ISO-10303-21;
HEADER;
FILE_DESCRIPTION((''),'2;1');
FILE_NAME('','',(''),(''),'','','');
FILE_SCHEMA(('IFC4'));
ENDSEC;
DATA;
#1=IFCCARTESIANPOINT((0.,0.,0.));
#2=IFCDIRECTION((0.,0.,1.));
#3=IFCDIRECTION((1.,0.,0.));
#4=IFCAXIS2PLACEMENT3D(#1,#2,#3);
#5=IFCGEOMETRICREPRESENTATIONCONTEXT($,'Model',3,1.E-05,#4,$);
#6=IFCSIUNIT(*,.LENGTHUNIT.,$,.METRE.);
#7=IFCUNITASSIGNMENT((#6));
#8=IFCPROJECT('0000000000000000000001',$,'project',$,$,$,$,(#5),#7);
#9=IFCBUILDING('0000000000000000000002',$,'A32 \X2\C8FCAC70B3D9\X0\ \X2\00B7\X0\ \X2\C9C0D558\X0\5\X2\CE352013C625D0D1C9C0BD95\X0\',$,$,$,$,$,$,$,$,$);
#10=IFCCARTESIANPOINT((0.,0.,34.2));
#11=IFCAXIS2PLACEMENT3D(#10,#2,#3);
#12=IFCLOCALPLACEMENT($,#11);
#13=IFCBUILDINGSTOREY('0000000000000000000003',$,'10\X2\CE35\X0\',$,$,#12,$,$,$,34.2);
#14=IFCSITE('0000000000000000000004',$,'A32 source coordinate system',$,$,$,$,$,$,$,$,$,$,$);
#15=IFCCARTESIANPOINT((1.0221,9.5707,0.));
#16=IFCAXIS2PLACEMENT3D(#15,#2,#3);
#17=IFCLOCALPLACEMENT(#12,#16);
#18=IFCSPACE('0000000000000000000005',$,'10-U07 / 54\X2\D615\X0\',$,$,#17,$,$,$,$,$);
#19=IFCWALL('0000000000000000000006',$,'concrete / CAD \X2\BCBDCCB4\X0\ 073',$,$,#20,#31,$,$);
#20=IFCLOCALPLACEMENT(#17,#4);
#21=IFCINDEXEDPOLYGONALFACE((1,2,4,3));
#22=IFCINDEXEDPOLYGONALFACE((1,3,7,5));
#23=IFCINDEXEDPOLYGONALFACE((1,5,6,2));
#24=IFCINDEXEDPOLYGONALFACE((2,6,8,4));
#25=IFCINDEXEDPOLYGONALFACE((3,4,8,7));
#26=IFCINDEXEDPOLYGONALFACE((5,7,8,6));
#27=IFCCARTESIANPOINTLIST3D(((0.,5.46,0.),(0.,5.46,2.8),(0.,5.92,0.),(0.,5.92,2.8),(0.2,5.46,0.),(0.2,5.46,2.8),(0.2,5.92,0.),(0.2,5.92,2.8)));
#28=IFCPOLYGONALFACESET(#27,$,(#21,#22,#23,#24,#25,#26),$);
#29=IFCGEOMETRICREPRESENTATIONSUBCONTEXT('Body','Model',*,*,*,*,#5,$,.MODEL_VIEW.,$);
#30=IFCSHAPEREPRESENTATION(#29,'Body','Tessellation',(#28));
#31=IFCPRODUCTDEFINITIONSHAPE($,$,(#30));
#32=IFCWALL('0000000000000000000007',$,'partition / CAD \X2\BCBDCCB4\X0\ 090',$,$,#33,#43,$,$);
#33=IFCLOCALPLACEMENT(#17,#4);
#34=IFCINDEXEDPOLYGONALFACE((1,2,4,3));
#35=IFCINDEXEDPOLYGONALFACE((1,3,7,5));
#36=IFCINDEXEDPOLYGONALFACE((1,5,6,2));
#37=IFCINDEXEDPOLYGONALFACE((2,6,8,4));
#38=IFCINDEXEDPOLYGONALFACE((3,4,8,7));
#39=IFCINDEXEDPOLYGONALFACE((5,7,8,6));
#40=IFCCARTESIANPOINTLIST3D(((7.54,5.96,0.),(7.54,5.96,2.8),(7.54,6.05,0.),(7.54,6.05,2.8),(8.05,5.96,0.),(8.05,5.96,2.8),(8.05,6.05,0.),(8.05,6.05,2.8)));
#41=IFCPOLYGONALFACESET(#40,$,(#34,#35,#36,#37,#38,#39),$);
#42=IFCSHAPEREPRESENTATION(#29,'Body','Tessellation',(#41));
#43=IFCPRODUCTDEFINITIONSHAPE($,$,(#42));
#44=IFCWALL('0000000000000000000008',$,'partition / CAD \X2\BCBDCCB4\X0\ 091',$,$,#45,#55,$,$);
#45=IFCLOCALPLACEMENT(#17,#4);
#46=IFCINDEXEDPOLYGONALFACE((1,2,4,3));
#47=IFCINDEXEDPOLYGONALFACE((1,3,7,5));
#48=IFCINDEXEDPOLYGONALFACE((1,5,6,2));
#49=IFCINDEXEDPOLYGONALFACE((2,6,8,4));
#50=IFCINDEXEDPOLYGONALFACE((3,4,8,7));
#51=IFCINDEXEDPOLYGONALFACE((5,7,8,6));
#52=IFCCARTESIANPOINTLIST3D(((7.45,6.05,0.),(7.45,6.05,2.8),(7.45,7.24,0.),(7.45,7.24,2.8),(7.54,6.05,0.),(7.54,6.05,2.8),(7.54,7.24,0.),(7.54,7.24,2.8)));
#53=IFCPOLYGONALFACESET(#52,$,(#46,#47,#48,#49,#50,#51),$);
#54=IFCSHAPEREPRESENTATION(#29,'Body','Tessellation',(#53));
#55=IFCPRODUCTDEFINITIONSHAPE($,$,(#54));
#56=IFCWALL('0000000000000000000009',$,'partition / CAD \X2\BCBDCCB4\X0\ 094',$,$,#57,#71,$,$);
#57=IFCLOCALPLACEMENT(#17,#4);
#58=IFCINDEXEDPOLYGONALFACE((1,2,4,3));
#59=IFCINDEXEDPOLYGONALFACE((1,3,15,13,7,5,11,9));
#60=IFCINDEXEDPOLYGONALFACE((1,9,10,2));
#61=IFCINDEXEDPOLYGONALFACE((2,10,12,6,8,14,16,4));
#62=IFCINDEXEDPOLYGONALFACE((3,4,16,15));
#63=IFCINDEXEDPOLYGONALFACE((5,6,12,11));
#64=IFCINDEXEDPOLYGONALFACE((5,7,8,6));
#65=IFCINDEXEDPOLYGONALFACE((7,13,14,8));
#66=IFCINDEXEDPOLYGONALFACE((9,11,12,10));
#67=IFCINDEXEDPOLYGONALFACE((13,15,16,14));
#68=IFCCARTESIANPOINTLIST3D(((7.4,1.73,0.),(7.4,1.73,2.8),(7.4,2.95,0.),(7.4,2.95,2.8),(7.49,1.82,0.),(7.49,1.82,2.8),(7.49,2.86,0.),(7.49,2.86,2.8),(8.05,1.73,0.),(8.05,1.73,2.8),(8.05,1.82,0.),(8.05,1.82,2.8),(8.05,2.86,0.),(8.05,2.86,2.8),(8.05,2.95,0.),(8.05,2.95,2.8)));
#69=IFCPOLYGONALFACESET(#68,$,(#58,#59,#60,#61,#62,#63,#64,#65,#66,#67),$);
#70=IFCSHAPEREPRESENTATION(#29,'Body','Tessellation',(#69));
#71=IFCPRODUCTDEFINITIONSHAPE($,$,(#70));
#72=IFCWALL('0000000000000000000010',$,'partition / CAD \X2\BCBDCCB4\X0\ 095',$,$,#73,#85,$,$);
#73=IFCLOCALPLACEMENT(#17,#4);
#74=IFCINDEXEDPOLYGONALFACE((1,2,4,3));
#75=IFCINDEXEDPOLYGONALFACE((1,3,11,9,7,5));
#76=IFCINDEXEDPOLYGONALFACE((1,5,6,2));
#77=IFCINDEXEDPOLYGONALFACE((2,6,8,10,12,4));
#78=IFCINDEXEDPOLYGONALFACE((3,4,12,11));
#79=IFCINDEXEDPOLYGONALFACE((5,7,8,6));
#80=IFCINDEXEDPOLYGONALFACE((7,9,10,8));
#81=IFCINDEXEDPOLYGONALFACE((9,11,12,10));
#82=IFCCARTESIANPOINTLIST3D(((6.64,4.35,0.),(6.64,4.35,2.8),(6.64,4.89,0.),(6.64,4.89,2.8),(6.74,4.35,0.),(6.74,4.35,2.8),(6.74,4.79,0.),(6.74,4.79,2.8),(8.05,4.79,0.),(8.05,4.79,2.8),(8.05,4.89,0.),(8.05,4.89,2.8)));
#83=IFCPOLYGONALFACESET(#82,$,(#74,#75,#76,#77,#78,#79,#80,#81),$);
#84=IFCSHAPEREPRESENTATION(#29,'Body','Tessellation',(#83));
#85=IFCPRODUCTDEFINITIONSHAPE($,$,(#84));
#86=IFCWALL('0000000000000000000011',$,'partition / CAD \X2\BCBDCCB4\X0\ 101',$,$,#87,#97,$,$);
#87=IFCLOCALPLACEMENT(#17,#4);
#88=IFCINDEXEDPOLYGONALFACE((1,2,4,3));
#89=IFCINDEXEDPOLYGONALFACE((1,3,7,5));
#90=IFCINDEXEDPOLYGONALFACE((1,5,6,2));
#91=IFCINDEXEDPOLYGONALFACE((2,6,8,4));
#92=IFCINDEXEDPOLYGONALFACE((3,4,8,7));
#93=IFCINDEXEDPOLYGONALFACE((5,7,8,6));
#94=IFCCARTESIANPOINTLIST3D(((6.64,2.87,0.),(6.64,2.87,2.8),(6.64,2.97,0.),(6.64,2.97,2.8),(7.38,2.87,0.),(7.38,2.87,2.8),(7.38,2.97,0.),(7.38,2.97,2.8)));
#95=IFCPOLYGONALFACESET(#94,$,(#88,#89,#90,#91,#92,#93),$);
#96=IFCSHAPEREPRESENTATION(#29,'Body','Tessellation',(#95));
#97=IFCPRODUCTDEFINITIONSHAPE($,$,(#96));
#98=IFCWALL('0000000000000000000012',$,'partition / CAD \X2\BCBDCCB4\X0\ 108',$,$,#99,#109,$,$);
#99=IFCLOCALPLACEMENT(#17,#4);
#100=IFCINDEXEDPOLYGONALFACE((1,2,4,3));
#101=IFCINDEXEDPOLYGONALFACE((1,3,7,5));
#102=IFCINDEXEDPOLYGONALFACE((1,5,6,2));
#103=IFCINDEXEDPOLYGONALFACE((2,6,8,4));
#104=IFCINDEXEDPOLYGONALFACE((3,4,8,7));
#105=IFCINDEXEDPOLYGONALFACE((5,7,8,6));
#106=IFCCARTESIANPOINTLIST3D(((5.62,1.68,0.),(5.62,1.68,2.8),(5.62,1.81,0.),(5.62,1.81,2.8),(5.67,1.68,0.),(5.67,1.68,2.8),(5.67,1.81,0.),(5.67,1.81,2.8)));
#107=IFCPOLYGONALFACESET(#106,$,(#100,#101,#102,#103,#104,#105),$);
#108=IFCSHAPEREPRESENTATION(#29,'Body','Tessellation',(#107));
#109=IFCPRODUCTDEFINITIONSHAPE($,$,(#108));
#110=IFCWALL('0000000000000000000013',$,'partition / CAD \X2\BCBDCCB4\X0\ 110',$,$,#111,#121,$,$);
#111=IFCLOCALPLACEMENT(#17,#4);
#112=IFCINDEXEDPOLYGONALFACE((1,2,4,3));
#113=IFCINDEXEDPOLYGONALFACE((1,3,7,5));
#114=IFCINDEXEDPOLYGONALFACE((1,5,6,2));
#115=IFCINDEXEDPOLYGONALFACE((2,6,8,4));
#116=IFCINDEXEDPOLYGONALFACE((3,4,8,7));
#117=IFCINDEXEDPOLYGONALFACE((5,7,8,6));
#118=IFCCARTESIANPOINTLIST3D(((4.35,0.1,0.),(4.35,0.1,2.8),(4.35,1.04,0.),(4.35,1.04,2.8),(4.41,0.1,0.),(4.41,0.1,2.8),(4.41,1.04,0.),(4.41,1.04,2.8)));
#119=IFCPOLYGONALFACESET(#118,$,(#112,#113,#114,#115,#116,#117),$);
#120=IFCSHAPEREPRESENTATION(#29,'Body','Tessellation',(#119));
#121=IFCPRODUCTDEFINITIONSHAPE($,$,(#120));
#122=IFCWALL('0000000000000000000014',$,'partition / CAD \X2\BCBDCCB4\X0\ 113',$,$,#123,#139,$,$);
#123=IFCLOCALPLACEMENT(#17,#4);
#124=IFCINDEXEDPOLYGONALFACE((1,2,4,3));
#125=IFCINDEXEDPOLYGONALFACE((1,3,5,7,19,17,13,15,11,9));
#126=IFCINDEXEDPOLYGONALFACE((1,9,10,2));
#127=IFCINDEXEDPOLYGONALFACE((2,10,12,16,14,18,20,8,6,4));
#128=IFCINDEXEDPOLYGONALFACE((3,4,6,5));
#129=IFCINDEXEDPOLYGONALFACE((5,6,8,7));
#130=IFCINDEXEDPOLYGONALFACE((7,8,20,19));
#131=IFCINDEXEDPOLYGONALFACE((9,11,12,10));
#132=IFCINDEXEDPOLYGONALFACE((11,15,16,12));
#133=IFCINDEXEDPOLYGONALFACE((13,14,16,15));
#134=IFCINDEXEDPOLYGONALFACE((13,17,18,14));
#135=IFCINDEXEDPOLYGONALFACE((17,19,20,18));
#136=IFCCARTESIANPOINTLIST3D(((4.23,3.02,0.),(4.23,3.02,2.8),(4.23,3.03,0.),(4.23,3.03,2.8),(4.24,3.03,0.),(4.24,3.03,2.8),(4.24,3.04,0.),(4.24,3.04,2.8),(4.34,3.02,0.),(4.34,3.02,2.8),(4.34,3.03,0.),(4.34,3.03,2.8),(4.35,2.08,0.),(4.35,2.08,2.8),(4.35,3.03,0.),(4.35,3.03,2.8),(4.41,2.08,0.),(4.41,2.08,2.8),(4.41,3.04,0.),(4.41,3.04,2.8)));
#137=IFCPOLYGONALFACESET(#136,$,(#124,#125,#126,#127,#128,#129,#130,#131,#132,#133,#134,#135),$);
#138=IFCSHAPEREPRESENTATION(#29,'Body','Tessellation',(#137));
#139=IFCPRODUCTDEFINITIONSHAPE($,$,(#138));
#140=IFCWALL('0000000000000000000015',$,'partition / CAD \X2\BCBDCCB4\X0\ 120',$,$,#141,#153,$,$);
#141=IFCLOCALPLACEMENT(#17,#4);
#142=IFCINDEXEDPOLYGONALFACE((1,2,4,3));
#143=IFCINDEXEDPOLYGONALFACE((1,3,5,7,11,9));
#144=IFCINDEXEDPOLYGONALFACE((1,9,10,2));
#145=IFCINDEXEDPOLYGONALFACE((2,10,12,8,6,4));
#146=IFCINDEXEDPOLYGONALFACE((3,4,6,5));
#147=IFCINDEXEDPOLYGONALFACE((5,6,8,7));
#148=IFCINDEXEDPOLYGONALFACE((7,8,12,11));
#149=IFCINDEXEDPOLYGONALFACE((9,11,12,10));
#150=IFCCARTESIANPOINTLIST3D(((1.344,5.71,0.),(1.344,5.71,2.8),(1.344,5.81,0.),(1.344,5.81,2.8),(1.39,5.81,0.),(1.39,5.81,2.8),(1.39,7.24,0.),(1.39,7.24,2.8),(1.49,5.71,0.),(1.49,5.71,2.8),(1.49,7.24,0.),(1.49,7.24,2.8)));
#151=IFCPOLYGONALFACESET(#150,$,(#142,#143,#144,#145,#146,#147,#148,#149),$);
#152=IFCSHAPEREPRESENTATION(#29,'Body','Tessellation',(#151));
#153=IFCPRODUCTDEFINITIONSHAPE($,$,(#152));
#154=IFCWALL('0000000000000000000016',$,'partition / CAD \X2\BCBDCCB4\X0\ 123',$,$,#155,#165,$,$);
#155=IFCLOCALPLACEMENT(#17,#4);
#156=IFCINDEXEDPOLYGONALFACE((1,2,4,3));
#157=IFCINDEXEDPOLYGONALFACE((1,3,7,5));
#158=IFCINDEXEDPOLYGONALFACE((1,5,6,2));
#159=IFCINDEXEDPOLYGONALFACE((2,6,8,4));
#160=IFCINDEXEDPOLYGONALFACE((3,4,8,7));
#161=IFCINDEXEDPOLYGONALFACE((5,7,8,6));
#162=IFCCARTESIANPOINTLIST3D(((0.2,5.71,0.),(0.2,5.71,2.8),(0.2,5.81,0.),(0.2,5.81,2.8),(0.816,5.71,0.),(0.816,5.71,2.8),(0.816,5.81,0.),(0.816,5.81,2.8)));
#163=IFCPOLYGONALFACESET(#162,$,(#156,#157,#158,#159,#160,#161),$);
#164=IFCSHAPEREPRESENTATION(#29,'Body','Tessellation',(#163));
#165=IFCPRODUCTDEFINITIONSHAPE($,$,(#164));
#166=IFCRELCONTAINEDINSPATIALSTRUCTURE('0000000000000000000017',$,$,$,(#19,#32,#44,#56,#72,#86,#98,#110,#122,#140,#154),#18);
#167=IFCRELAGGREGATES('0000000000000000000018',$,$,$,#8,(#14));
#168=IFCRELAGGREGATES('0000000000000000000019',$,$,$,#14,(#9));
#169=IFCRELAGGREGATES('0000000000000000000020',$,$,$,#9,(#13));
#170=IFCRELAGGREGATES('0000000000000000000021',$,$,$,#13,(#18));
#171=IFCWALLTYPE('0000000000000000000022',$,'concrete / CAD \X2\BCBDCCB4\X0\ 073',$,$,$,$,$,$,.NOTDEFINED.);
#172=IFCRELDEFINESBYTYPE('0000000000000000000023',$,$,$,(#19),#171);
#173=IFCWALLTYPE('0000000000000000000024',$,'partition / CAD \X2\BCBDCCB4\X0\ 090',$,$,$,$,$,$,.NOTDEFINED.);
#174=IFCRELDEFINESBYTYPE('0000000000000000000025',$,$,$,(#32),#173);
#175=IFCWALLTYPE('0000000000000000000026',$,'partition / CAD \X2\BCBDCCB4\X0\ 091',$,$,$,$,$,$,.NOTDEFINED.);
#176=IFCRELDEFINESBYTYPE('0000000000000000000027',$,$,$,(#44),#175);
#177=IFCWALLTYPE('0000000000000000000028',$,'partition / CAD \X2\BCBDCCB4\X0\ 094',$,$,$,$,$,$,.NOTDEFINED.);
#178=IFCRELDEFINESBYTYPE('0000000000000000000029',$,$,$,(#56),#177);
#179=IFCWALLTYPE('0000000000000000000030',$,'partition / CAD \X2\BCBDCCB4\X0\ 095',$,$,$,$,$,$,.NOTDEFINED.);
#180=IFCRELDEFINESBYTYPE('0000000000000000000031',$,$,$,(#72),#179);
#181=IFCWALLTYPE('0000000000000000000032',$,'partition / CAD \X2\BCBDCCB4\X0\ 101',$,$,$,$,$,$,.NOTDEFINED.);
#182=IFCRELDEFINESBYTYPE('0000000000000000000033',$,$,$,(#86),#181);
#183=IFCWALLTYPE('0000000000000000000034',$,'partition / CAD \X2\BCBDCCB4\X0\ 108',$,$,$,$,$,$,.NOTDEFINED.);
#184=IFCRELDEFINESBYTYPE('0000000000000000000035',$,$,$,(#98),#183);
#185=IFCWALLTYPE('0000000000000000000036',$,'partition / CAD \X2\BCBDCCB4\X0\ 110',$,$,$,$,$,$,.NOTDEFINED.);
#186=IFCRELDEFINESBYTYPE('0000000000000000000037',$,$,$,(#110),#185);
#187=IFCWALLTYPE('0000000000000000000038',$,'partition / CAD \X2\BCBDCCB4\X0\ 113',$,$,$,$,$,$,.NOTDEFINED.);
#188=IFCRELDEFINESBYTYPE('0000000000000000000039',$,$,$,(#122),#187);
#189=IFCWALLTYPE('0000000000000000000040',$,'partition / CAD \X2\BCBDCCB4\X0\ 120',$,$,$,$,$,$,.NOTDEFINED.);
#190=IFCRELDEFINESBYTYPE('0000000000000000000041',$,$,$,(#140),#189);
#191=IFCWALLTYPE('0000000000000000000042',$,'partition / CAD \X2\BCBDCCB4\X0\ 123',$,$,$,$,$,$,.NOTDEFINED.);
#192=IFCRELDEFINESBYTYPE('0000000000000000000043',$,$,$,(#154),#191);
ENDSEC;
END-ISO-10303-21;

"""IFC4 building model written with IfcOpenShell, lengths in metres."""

from ifc_helpers import new_model, si_unit, frame, origin, origin_with_axes, place, context, subcontext, project, spatial, polyline, outline, extrude, source, transform, mapped, type_object, type_shapes, element, save


model = new_model("IFC4")

# Units and contexts
model_context = context("Model", 3, precision=1e-05, world=origin_with_axes())
body_context = subcontext(model_context, "Body", "Model", "MODEL_VIEW")
ifc_project = project(units=[si_unit("LENGTHUNIT", "METRE")], contexts=[model_context])

# Site, building, storey, space
site = spatial("IfcSite", under=ifc_project, Name="A32 source coordinate system")
building = spatial("IfcBuilding", under=site, Name="A32 주거동 · 지하5층–옥탑지붕")
storey_placement = place(None, frame((0.0, 0.0, 34.2), z_axis=(0.0, 0.0, 1.0), x_axis=(1.0, 0.0, 0.0)))
storey = spatial("IfcBuildingStorey", under=building, at=storey_placement, Name="10층", Elevation=34.2)
space_1_placement = place(storey_placement, frame((1.0221, 9.5707, 0.0), z_axis=(0.0, 0.0, 1.0), x_axis=(1.0, 0.0, 0.0)))
space_1 = spatial("IfcSpace", under=storey, at=space_1_placement, Name="10-U07 / 54형")

# Walls
wall_type_1 = type_object("IfcWallType", Name="concrete / CAD 벽체 073", PredefinedType="NOTDEFINED")
shared_shape_1 = source(origin(), body_context, "Body", "SweptSolid", [
    extrude(outline(polyline([(0.2, 5.92), (0.2, 5.46), (0.0, 5.46), (0.0, 5.92), (0.2, 5.92)])), origin(), (0.0, 0.0, 1.0), 2.8),
])
type_shapes(wall_type_1, [shared_shape_1])
wall_1_placement = place(space_1_placement, origin_with_axes())
element("IfcWall", 1, at=wall_1_placement, inside=space_1, type_object=wall_type_1, Name="concrete / CAD 벽체 073", context=body_context, shape_type="MappedRepresentation", body=[
    mapped(shared_shape_1, transform((0.0, 0.0, 0.0), scale=1.0)),
])
wall_type_2 = type_object("IfcWallType", Name="partition / CAD 벽체 090", PredefinedType="NOTDEFINED")
shared_shape_2 = source(origin(), body_context, "Body", "SweptSolid", [
    extrude(outline(polyline([(7.54, 5.96), (7.54, 6.05), (8.05, 6.05), (8.05, 5.96), (7.54, 5.96)])), origin(), (0.0, 0.0, 1.0), 2.8),
])
type_shapes(wall_type_2, [shared_shape_2])
wall_2_placement = place(space_1_placement, origin_with_axes())
element("IfcWall", 2, at=wall_2_placement, inside=space_1, type_object=wall_type_2, Name="partition / CAD 벽체 090", context=body_context, shape_type="MappedRepresentation", body=[
    mapped(shared_shape_2, transform((0.0, 0.0, 0.0), scale=1.0)),
])
wall_type_3 = type_object("IfcWallType", Name="partition / CAD 벽체 091", PredefinedType="NOTDEFINED")
shared_shape_3 = source(origin(), body_context, "Body", "SweptSolid", [
    extrude(outline(polyline([(7.54, 6.05), (7.45, 6.05), (7.45, 7.24), (7.54, 7.24), (7.54, 6.05)])), origin(), (0.0, 0.0, 1.0), 2.8),
])
type_shapes(wall_type_3, [shared_shape_3])
wall_3_placement = place(space_1_placement, origin_with_axes())
element("IfcWall", 3, at=wall_3_placement, inside=space_1, type_object=wall_type_3, Name="partition / CAD 벽체 091", context=body_context, shape_type="MappedRepresentation", body=[
    mapped(shared_shape_3, transform((0.0, 0.0, 0.0), scale=1.0)),
])
wall_type_4 = type_object("IfcWallType", Name="partition / CAD 벽체 094", PredefinedType="NOTDEFINED")
shared_shape_4 = source(origin(), body_context, "Body", "SweptSolid", [
    extrude(outline(polyline([(8.05, 1.73), (7.4, 1.73), (7.4, 2.95), (8.05, 2.95), (8.05, 2.86), (7.49, 2.86), (7.49, 1.82), (8.05, 1.82), (8.05, 1.73)])), origin(), (0.0, 0.0, 1.0), 2.8),
])
type_shapes(wall_type_4, [shared_shape_4])
wall_4_placement = place(space_1_placement, origin_with_axes())
element("IfcWall", 4, at=wall_4_placement, inside=space_1, type_object=wall_type_4, Name="partition / CAD 벽체 094", context=body_context, shape_type="MappedRepresentation", body=[
    mapped(shared_shape_4, transform((0.0, 0.0, 0.0), scale=1.0)),
])
wall_type_5 = type_object("IfcWallType", Name="partition / CAD 벽체 095", PredefinedType="NOTDEFINED")
shared_shape_5 = source(origin(), body_context, "Body", "SweptSolid", [
    extrude(outline(polyline([(6.64, 4.89), (8.05, 4.89), (8.05, 4.79), (6.74, 4.79), (6.74, 4.35), (6.64, 4.35), (6.64, 4.89)])), origin(), (0.0, 0.0, 1.0), 2.8),
])
type_shapes(wall_type_5, [shared_shape_5])
wall_5_placement = place(space_1_placement, origin_with_axes())
element("IfcWall", 5, at=wall_5_placement, inside=space_1, type_object=wall_type_5, Name="partition / CAD 벽체 095", context=body_context, shape_type="MappedRepresentation", body=[
    mapped(shared_shape_5, transform((0.0, 0.0, 0.0), scale=1.0)),
])
wall_type_6 = type_object("IfcWallType", Name="partition / CAD 벽체 101", PredefinedType="NOTDEFINED")
shared_shape_6 = source(origin(), body_context, "Body", "SweptSolid", [
    extrude(outline(polyline([(7.38, 2.97), (7.38, 2.87), (6.64, 2.87), (6.64, 2.97), (7.38, 2.97)])), origin(), (0.0, 0.0, 1.0), 2.8),
])
type_shapes(wall_type_6, [shared_shape_6])
wall_6_placement = place(space_1_placement, origin_with_axes())
element("IfcWall", 6, at=wall_6_placement, inside=space_1, type_object=wall_type_6, Name="partition / CAD 벽체 101", context=body_context, shape_type="MappedRepresentation", body=[
    mapped(shared_shape_6, transform((0.0, 0.0, 0.0), scale=1.0)),
])
wall_type_7 = type_object("IfcWallType", Name="partition / CAD 벽체 108", PredefinedType="NOTDEFINED")
shared_shape_7 = source(origin(), body_context, "Body", "SweptSolid", [
    extrude(outline(polyline([(5.67, 1.68), (5.62, 1.68), (5.62, 1.81), (5.67, 1.81), (5.67, 1.68)])), origin(), (0.0, 0.0, 1.0), 2.8),
])
type_shapes(wall_type_7, [shared_shape_7])
wall_7_placement = place(space_1_placement, origin_with_axes())
element("IfcWall", 7, at=wall_7_placement, inside=space_1, type_object=wall_type_7, Name="partition / CAD 벽체 108", context=body_context, shape_type="MappedRepresentation", body=[
    mapped(shared_shape_7, transform((0.0, 0.0, 0.0), scale=1.0)),
])
wall_type_8 = type_object("IfcWallType", Name="partition / CAD 벽체 110", PredefinedType="NOTDEFINED")
shared_shape_8 = source(origin(), body_context, "Body", "SweptSolid", [
    extrude(outline(polyline([(4.35, 1.04), (4.41, 1.04), (4.41, 0.1), (4.35, 0.1), (4.35, 1.04)])), origin(), (0.0, 0.0, 1.0), 2.8),
])
type_shapes(wall_type_8, [shared_shape_8])
wall_8_placement = place(space_1_placement, origin_with_axes())
element("IfcWall", 8, at=wall_8_placement, inside=space_1, type_object=wall_type_8, Name="partition / CAD 벽체 110", context=body_context, shape_type="MappedRepresentation", body=[
    mapped(shared_shape_8, transform((0.0, 0.0, 0.0), scale=1.0)),
])
wall_type_9 = type_object("IfcWallType", Name="partition / CAD 벽체 113", PredefinedType="NOTDEFINED")
shared_shape_9 = source(origin(), body_context, "Body", "SweptSolid", [
    extrude(outline(polyline([(4.24, 3.04), (4.41, 3.04), (4.41, 2.08), (4.35, 2.08), (4.35, 3.03), (4.34, 3.03), (4.34, 3.02), (4.23, 3.02), (4.23, 3.03), (4.24, 3.03), (4.24, 3.04)])), origin(), (0.0, 0.0, 1.0), 2.8),
])
type_shapes(wall_type_9, [shared_shape_9])
wall_9_placement = place(space_1_placement, origin_with_axes())
element("IfcWall", 9, at=wall_9_placement, inside=space_1, type_object=wall_type_9, Name="partition / CAD 벽체 113", context=body_context, shape_type="MappedRepresentation", body=[
    mapped(shared_shape_9, transform((0.0, 0.0, 0.0), scale=1.0)),
])
wall_type_10 = type_object("IfcWallType", Name="partition / CAD 벽체 120", PredefinedType="NOTDEFINED")
shared_shape_10 = source(origin(), body_context, "Body", "SweptSolid", [
    extrude(outline(polyline([(1.39, 7.24), (1.49, 7.24), (1.49, 5.71), (1.344, 5.71), (1.344, 5.81), (1.39, 5.81), (1.39, 7.24)])), origin(), (0.0, 0.0, 1.0), 2.8),
])
type_shapes(wall_type_10, [shared_shape_10])
wall_10_placement = place(space_1_placement, origin_with_axes())
element("IfcWall", 10, at=wall_10_placement, inside=space_1, type_object=wall_type_10, Name="partition / CAD 벽체 120", context=body_context, shape_type="MappedRepresentation", body=[
    mapped(shared_shape_10, transform((0.0, 0.0, 0.0), scale=1.0)),
])
wall_type_11 = type_object("IfcWallType", Name="partition / CAD 벽체 123", PredefinedType="NOTDEFINED")
shared_shape_11 = source(origin(), body_context, "Body", "SweptSolid", [
    extrude(outline(polyline([(0.816, 5.81), (0.816, 5.71), (0.2, 5.71), (0.2, 5.81), (0.816, 5.81)])), origin(), (0.0, 0.0, 1.0), 2.8),
])
type_shapes(wall_type_11, [shared_shape_11])
wall_11_placement = place(space_1_placement, origin_with_axes())
element("IfcWall", 11, at=wall_11_placement, inside=space_1, type_object=wall_type_11, Name="partition / CAD 벽체 123", context=body_context, shape_type="MappedRepresentation", body=[
    mapped(shared_shape_11, transform((0.0, 0.0, 0.0), scale=1.0)),
])

save(model, "model.ifc")
